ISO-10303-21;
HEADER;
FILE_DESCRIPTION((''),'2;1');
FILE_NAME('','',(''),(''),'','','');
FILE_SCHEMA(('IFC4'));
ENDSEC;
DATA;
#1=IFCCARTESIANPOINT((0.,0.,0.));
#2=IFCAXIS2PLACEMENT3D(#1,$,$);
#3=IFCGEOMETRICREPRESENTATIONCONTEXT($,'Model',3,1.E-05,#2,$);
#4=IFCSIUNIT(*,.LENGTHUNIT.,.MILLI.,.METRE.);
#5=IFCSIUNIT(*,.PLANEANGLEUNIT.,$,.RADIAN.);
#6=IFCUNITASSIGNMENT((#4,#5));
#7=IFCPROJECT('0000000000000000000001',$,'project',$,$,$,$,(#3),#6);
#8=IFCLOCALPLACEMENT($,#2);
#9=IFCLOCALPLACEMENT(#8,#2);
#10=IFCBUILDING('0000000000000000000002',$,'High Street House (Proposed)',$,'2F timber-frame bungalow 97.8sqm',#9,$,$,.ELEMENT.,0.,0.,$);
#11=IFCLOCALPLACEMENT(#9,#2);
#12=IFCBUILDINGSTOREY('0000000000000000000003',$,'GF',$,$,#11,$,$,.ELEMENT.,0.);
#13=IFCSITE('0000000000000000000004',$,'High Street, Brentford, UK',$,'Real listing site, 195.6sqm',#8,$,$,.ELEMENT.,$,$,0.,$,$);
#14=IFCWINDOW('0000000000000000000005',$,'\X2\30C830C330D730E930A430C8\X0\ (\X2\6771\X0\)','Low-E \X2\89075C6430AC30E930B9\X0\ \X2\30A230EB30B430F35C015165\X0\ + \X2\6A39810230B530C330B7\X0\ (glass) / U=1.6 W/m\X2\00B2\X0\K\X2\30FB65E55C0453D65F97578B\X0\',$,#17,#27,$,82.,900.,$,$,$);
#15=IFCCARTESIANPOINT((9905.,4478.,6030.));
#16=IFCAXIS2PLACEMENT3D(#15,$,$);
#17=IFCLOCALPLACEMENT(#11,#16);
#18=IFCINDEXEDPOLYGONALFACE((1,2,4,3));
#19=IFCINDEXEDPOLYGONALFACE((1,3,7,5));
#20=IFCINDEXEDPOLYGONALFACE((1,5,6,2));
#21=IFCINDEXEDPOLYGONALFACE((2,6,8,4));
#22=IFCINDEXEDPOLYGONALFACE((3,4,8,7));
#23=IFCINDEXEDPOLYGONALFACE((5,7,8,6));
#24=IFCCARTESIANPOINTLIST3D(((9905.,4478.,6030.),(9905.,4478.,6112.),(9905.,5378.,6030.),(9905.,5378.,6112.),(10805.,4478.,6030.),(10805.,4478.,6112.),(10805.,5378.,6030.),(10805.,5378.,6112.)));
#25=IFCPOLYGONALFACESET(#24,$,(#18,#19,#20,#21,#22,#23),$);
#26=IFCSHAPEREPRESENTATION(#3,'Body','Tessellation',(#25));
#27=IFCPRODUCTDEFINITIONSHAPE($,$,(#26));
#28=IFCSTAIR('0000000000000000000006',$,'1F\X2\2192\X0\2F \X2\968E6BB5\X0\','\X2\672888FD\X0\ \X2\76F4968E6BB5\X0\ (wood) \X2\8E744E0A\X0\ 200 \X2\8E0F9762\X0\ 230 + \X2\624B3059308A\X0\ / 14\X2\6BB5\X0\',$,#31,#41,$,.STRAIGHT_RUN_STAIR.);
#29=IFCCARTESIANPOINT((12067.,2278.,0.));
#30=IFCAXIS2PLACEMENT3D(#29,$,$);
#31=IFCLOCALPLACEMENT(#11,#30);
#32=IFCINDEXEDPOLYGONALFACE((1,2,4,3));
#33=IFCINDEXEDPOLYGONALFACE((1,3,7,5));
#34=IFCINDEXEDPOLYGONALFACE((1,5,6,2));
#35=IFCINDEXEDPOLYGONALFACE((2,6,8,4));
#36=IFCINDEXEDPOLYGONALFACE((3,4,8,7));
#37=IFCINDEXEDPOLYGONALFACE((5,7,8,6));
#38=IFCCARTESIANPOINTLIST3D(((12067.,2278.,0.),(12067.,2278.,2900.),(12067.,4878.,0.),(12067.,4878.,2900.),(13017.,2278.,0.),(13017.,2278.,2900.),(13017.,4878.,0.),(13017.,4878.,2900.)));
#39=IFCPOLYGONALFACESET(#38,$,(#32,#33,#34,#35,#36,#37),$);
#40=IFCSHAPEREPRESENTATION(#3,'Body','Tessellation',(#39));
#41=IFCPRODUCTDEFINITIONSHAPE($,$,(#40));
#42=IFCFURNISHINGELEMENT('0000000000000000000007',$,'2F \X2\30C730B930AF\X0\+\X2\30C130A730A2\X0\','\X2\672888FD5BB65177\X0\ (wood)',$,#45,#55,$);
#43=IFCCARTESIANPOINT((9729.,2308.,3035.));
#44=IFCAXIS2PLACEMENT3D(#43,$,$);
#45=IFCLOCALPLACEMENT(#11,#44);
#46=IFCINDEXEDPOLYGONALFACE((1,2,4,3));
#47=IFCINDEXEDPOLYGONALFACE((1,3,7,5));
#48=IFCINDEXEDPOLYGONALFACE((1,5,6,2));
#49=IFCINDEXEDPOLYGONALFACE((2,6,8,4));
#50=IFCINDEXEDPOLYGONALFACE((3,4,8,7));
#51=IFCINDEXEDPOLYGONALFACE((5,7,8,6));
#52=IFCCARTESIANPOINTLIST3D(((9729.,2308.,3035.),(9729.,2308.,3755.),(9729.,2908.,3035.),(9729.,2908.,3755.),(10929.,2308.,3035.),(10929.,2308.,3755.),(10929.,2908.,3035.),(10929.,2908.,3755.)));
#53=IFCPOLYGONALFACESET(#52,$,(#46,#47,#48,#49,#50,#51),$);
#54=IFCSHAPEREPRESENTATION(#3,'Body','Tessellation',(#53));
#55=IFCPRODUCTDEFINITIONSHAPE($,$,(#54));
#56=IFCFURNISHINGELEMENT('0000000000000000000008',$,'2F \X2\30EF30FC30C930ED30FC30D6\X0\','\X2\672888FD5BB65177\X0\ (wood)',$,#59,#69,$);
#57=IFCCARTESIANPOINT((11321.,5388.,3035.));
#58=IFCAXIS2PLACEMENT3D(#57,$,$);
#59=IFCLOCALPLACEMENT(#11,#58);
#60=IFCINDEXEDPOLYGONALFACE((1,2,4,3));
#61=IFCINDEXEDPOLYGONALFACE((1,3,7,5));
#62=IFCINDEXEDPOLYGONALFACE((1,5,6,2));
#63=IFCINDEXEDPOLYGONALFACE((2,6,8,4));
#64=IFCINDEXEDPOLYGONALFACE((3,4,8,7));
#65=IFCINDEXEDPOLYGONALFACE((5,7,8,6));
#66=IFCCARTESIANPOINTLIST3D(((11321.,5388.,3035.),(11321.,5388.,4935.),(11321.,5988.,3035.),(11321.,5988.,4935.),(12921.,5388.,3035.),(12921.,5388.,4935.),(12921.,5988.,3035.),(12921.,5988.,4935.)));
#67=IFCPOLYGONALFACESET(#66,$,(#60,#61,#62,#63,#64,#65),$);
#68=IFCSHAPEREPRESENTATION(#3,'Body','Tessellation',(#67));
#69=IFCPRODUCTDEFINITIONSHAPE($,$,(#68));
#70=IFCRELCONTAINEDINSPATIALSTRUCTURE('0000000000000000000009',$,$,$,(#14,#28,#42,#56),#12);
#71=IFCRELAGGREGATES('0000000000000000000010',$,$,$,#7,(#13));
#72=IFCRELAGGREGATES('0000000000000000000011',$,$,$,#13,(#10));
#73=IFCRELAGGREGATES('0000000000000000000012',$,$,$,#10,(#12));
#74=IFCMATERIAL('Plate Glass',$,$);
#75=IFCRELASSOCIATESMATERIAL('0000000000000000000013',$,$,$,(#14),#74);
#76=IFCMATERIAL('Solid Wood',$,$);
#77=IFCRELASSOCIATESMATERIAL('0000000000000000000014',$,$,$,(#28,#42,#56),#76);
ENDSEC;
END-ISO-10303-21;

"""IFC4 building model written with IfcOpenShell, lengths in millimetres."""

from ifc_helpers import new_model, si_unit, frame, frame_2d, origin, place, context, project, spatial, rectangle, extrude, material, element, save


model = new_model("IFC4")

# Units and contexts
model_context = context("Model", 3, precision=1e-05, world=origin())
ifc_project = project(units=[si_unit("LENGTHUNIT", "METRE", prefix="MILLI"), si_unit("PLANEANGLEUNIT", "RADIAN")], contexts=[model_context])

# Site, building, storey
site_placement = place(None, origin())
site = spatial("IfcSite", under=ifc_project, at=site_placement, Name="High Street, Brentford, UK", ObjectType="Real listing site, 195.6sqm", CompositionType="ELEMENT", RefElevation=0.0)
building_placement = place(site_placement, origin())
building = spatial("IfcBuilding", under=site, at=building_placement, Name="High Street House (Proposed)", ObjectType="2F timber-frame bungalow 97.8sqm", CompositionType="ELEMENT", ElevationOfRefHeight=0.0, ElevationOfTerrain=0.0)
storey_placement = place(building_placement, origin())
storey = spatial("IfcBuildingStorey", under=building, at=storey_placement, Name="GF", CompositionType="ELEMENT", Elevation=0.0)

# Shared definitions
ifc_material_1 = material(Name="Solid Wood")

# Shared definitions
ifc_material_2 = material(Name="Plate Glass")

# Window
window_1_placement = place(storey_placement, frame((9905.0, 4478.0, 6030.0)))
element("IfcWindow", 1, at=window_1_placement, inside=storey, material=ifc_material_2, Name="トップライト (東)", Description="Low-E 複層ガラス アルゴン封入 + 樹脂サッシ (glass) / U=1.6 W/m²K・日射取得型", OverallHeight=82.0, OverallWidth=900.0, context=model_context, shape_type="SweptSolid", body=[
    extrude(rectangle(XDim=900.0, YDim=900.0, at=frame_2d((450.0, 450.0))), frame((9905.0, 4478.0, 6030.0)), (0.0, 0.0, 1.0), 82.0),
])

# Stair
stair_placement = place(storey_placement, frame((12067.0, 2278.0, 0.0)))
element("IfcStair", 2, at=stair_placement, inside=storey, material=ifc_material_1, Name="1F→2F 階段", Description="木製 直階段 (wood) 蹴上 200 踏面 230 + 手すり / 14段", PredefinedType="STRAIGHT_RUN_STAIR", context=model_context, shape_type="SweptSolid", body=[
    extrude(rectangle(XDim=950.0, YDim=2600.0, at=frame_2d((475.0, 1300.0))), frame((12067.0, 2278.0, 0.0)), (0.0, 0.0, 1.0), 2900.0),
])

# Furnishing elements
furnishing_1_placement = place(storey_placement, frame((9729.0, 2308.0, 3035.0)))
element("IfcFurnishingElement", 3, at=furnishing_1_placement, inside=storey, material=ifc_material_1, Name="2F デスク+チェア", Description="木製家具 (wood)", context=model_context, shape_type="SweptSolid", body=[
    extrude(rectangle(XDim=1200.0, YDim=600.0, at=frame_2d((600.0, 300.0))), frame((9729.0, 2308.0, 3035.0)), (0.0, 0.0, 1.0), 720.0),
])
furnishing_2_placement = place(storey_placement, frame((11321.0, 5388.0, 3035.0)))
element("IfcFurnishingElement", 4, at=furnishing_2_placement, inside=storey, material=ifc_material_1, Name="2F ワードローブ", Description="木製家具 (wood)", context=model_context, shape_type="SweptSolid", body=[
    extrude(rectangle(XDim=1600.0, YDim=600.0, at=frame_2d((800.0, 300.0))), frame((11321.0, 5388.0, 3035.0)), (0.0, 0.0, 1.0), 1900.0),
])

save(model, "model.ifc")
